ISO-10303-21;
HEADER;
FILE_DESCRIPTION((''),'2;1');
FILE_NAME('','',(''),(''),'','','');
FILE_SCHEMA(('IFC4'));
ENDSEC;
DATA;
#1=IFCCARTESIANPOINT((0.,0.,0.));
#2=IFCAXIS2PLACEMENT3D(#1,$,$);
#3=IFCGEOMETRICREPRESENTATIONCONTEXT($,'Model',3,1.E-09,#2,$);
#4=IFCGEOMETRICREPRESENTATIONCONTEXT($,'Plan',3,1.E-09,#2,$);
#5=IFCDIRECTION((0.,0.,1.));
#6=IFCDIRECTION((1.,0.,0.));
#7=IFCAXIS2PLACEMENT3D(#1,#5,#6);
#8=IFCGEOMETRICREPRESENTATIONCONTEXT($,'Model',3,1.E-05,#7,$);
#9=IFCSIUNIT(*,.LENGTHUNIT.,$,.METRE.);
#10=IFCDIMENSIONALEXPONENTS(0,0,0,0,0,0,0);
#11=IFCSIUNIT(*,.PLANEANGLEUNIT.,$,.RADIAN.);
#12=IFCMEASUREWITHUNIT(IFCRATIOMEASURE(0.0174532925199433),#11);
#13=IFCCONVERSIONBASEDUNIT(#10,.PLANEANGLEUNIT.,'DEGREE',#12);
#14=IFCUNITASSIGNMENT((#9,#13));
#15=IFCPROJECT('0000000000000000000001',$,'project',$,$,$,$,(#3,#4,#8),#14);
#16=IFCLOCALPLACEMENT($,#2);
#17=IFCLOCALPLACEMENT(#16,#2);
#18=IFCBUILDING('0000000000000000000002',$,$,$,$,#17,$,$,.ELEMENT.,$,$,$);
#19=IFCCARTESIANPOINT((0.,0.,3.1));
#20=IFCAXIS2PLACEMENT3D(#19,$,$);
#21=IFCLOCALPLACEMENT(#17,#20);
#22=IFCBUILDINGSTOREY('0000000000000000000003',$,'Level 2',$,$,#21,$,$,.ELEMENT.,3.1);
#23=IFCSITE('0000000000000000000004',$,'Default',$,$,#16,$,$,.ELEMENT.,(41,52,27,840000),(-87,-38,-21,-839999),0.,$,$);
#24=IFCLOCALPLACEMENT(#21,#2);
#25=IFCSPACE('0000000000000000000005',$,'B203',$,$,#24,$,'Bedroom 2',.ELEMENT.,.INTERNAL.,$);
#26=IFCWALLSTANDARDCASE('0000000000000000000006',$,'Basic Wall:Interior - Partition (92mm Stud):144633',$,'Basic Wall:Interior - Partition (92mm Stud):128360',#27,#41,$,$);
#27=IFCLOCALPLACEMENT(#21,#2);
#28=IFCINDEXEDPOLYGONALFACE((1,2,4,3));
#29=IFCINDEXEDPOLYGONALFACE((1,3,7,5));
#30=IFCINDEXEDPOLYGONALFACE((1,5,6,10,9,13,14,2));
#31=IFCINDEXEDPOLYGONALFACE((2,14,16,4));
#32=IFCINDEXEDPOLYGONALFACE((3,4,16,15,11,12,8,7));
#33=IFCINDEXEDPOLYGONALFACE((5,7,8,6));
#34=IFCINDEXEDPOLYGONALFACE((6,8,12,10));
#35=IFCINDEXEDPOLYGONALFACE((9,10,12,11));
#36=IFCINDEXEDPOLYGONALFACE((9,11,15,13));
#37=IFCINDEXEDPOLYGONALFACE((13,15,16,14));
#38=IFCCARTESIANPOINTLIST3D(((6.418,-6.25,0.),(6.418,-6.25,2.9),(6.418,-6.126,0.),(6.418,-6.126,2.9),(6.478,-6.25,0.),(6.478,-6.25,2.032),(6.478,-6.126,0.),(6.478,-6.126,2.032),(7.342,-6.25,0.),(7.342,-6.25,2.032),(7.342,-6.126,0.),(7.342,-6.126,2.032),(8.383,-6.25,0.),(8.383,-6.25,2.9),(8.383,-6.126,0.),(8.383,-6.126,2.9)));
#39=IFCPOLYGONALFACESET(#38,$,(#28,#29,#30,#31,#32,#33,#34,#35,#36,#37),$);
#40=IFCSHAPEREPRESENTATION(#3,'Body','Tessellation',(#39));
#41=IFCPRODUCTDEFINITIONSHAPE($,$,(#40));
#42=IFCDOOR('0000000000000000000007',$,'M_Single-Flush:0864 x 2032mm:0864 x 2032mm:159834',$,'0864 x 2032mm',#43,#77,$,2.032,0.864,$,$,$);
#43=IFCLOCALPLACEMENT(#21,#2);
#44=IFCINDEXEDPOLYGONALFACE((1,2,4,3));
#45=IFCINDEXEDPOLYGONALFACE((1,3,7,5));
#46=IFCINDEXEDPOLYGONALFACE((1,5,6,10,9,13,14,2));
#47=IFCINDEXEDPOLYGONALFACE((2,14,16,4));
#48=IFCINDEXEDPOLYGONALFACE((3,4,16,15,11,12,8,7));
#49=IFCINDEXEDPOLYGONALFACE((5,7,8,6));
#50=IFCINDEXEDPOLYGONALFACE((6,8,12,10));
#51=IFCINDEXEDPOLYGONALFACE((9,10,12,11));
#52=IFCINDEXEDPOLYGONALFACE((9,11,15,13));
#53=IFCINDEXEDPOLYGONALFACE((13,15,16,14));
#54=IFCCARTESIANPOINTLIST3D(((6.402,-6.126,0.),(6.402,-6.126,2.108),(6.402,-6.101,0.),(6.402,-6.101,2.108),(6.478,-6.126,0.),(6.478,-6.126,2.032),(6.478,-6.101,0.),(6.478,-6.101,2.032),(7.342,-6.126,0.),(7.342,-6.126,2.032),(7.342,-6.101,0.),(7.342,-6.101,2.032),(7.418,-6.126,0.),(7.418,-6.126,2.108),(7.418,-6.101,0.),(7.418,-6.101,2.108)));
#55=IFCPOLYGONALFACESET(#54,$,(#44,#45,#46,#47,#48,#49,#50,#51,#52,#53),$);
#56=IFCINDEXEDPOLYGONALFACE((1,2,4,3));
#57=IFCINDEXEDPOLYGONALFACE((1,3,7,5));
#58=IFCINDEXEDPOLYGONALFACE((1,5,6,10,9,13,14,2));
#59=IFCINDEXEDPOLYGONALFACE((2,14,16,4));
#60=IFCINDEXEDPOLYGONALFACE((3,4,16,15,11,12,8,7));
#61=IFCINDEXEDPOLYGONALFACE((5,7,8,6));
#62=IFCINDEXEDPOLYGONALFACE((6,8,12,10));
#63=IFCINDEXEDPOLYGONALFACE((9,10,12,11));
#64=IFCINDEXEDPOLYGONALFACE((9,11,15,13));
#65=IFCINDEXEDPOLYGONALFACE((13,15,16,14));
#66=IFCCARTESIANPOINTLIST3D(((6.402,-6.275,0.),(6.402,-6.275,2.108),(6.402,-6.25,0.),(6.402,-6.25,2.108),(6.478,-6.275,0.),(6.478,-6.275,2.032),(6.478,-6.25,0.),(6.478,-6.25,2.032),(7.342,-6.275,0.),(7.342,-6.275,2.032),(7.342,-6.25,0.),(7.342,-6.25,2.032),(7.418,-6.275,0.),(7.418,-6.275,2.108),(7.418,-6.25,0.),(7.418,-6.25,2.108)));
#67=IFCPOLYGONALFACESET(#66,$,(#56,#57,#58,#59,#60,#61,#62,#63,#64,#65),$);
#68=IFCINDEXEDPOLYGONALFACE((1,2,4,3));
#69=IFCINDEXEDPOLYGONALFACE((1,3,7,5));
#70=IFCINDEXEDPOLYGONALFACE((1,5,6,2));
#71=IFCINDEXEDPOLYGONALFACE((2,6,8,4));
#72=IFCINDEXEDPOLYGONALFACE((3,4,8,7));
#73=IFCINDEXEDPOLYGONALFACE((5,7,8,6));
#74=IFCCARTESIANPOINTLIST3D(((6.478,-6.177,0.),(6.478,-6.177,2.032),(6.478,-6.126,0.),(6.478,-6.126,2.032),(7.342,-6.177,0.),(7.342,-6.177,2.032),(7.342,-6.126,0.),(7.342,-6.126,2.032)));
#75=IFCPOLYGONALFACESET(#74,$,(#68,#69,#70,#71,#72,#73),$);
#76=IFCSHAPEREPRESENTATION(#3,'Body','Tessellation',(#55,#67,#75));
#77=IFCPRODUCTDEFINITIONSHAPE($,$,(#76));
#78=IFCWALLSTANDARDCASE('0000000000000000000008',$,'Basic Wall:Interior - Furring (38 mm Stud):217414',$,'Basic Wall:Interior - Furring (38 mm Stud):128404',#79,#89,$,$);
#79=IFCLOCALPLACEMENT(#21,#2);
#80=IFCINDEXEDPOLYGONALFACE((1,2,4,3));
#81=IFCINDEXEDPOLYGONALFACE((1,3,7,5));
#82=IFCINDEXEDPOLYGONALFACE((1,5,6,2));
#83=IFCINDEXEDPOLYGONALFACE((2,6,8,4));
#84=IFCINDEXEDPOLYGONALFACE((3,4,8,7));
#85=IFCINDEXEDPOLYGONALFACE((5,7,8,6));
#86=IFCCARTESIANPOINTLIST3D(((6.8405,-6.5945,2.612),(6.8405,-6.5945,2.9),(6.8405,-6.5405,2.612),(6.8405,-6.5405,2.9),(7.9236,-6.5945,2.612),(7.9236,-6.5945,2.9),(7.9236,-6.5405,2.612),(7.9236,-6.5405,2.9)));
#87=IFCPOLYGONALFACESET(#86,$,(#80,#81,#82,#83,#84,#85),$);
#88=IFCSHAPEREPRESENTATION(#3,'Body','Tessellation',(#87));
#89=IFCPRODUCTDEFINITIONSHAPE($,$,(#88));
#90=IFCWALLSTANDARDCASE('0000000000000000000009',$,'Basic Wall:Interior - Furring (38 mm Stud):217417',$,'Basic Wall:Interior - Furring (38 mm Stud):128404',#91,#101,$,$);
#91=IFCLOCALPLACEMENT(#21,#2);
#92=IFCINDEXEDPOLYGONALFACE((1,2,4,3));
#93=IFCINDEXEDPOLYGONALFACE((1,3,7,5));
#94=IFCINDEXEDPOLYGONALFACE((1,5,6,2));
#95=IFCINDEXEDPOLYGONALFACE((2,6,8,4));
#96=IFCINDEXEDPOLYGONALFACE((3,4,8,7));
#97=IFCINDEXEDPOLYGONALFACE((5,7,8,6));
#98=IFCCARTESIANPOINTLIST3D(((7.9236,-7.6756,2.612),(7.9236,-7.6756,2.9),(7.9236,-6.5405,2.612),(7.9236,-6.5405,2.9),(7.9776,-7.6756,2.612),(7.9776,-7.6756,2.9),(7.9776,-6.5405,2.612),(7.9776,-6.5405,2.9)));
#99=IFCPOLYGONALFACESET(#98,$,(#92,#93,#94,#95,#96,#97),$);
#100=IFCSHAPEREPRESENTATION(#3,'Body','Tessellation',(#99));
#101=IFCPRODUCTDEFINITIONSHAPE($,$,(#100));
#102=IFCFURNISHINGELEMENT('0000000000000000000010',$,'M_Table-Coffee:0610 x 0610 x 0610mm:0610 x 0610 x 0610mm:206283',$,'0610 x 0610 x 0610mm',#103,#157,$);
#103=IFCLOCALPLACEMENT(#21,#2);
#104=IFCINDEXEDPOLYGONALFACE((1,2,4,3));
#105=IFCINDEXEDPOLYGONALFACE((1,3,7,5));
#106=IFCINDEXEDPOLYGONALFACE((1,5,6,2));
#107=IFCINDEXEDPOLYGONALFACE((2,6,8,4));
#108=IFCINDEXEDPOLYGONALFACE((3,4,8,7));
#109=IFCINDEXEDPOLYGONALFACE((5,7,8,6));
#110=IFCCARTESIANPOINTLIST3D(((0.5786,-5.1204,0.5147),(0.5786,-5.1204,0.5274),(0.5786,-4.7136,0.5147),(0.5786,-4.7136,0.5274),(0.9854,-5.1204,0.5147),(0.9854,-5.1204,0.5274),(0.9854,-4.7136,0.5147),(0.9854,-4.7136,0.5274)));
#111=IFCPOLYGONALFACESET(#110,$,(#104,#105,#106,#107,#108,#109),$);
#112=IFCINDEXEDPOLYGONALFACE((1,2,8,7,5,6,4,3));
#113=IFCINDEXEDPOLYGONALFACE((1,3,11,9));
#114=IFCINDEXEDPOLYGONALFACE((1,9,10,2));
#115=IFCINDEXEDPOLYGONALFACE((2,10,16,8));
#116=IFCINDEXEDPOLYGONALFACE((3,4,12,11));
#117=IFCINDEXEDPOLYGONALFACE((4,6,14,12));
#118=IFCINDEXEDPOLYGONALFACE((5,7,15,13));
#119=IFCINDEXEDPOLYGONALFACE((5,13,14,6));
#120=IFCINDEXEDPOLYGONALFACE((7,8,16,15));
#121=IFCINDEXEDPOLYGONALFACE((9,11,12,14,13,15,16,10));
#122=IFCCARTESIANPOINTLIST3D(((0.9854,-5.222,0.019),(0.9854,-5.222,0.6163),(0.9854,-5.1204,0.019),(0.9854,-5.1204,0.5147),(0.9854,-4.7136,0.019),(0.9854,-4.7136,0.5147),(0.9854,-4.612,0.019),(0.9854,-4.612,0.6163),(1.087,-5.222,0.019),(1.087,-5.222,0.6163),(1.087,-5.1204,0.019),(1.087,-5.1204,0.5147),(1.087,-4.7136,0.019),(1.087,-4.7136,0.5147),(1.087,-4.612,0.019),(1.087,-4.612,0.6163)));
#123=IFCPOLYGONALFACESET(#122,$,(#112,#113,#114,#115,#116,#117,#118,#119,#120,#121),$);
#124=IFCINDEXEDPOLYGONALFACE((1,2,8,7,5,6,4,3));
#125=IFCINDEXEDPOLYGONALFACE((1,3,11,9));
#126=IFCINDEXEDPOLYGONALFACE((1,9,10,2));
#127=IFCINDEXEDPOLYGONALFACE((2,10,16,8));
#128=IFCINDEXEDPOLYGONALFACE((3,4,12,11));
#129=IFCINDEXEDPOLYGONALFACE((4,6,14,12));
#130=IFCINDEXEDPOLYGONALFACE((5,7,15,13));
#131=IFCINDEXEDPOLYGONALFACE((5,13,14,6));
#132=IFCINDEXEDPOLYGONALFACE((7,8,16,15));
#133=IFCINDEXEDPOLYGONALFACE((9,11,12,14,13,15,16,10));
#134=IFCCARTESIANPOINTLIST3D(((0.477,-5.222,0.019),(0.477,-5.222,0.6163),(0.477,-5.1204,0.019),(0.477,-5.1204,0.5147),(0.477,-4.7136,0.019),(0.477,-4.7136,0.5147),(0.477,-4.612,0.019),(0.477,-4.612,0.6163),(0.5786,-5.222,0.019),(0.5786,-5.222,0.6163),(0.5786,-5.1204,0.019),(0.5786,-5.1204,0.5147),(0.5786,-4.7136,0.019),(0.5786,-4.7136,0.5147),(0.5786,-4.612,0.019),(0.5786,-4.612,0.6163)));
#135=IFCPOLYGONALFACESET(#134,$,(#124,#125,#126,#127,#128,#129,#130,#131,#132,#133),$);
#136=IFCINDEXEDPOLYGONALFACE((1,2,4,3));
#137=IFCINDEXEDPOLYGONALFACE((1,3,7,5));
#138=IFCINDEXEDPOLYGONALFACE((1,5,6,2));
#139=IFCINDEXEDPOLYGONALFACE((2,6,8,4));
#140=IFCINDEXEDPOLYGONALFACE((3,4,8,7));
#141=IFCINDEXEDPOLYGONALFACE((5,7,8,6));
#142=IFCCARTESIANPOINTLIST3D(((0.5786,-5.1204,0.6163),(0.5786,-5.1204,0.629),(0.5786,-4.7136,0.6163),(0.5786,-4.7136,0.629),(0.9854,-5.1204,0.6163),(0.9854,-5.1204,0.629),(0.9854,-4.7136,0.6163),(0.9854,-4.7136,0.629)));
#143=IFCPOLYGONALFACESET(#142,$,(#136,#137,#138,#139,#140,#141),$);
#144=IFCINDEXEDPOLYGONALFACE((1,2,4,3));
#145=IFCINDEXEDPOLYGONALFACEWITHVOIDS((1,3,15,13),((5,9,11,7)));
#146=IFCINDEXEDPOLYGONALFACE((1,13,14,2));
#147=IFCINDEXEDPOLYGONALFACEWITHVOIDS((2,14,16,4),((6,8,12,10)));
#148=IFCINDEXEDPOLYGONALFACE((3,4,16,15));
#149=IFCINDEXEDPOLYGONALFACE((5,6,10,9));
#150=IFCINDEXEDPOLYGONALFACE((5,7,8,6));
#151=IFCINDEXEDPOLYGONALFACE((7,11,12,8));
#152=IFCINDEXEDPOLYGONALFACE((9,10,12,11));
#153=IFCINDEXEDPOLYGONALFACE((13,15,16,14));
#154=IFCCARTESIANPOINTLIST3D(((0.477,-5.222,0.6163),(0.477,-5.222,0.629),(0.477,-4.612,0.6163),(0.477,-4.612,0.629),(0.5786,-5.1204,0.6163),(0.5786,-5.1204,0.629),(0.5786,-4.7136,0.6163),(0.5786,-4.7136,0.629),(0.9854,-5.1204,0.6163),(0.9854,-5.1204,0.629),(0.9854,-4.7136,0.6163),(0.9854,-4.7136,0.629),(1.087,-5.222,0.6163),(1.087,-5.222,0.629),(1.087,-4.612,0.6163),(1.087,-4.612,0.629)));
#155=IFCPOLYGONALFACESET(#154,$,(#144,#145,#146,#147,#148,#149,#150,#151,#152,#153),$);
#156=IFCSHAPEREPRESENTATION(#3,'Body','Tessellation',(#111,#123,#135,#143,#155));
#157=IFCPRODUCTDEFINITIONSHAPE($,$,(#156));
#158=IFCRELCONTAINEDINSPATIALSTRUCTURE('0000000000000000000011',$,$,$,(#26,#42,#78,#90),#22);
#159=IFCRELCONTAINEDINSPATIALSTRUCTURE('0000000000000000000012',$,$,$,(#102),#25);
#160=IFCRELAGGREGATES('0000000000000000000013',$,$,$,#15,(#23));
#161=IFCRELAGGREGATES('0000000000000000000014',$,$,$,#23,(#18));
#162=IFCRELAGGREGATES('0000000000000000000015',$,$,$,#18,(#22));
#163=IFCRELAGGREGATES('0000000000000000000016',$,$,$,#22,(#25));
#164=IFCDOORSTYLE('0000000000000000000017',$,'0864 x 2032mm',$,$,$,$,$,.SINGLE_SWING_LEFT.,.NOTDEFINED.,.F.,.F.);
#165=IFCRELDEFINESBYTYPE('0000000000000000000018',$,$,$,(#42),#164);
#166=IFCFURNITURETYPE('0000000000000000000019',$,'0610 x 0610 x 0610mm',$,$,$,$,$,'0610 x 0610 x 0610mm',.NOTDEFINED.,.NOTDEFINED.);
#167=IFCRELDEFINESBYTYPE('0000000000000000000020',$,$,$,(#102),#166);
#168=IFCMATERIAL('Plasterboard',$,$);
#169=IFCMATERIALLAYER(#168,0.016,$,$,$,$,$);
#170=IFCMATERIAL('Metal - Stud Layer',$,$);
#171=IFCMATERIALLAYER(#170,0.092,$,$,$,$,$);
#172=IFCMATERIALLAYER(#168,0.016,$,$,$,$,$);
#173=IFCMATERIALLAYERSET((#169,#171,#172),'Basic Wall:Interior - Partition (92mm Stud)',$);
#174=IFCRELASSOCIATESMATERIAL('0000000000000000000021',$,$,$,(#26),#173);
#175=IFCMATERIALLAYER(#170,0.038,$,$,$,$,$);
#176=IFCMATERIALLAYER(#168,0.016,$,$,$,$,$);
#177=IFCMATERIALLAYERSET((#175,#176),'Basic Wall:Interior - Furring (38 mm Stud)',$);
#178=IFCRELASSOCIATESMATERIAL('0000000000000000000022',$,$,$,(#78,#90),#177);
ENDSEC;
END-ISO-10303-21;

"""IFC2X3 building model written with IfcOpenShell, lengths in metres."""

from ifc_helpers import new_model, entity, si_unit, converted_unit, frame, frame_2d, origin, origin_with_axes, origin_2d_with_axis, place, context, project, spatial, polyline, rectangle, outline, extrude, source, transform, mapped, material, layer, layer_set, layer_usage, type_object, type_shapes, element, fill, save


model = new_model("IFC2X3")

# Units and contexts
model_context_1 = context("Model", 3, precision=1e-09, world=origin())
plan_context = context("Plan", 3, precision=1e-09, world=origin())
model_context_2 = context("Model", 3, precision=1e-05, world=origin_with_axes())
ifc_project = project(units=[si_unit("LENGTHUNIT", "METRE"), converted_unit("PLANEANGLEUNIT", "DEGREE", entity("IfcRatioMeasure", 0.0174532925199433), si_unit("PLANEANGLEUNIT", "RADIAN"), dimensions=[0, 0, 0, 0, 0, 0, 0])], contexts=[model_context_1, plan_context, model_context_2])

# Site, building, storey
site_placement = place(None, origin())
site = spatial("IfcSite", under=ifc_project, at=site_placement, Name="Default", CompositionType="ELEMENT", RefLatitude=(41, 52, 27, 840000), RefLongitude=(-87, -38, -21, -839999), RefElevation=0.0)
building_placement = place(site_placement, origin())
building = spatial("IfcBuilding", under=site, at=building_placement, CompositionType="ELEMENT")
storey_placement = place(building_placement, frame((0.0, 0.0, 3.1)))
storey = spatial("IfcBuildingStorey", under=building, at=storey_placement, Name="Level 2", CompositionType="ELEMENT", Elevation=3.1)

# Shared definitions
ifc_material_1 = material(Name="Metal - Stud Layer")
ifc_material_2 = material(Name="Plasterboard")

# Wall, opening, door
ifc_layer_1 = layer(ifc_material_2, 0.016)
ifc_layer_2 = layer(ifc_material_1, 0.092)
ifc_layer_3 = layer(ifc_material_2, 0.016)
ifc_layer_set_1 = layer_set([ifc_layer_1, ifc_layer_2, ifc_layer_3], Name="Basic Wall:Interior - Partition (92mm Stud)")
ifc_layer_usage_1 = layer_usage(ifc_layer_set_1, "AXIS2", "NEGATIVE", 0.062)
wall_1_placement = place(storey_placement, frame((6.418, -6.188, 0.0)))
wall_1 = element("IfcWallStandardCase", 1, at=wall_1_placement, inside=storey, material=ifc_layer_usage_1, Name="Basic Wall:Interior - Partition (92mm Stud):144633", ObjectType="Basic Wall:Interior - Partition (92mm Stud):128360", context=model_context_1, shape_type="SweptSolid", body=[
    extrude(rectangle(XDim=1.965, YDim=0.124, at=frame_2d((0.9825, 0.0), x_axis=(-1.0, 0.0))), origin(), (0.0, 0.0, 1.0), 2.9),
])
opening_1_placement = place(wall_1_placement, frame((0.06, -0.062, 0.0)))
opening_1 = element("IfcOpeningElement", 2, at=opening_1_placement, cuts=wall_1, ObjectType="Opening", context=model_context_1, shape_type="SweptSolid", body=[
    extrude(rectangle(XDim=0.864, YDim=2.032, at=frame_2d((1.016, 0.432), x_axis=(0.0, -1.0))), frame((0.0, 0.0, 0.0), z_axis=(0.0, 1.0, 0.0), x_axis=(0.0, 0.0, 1.0)), (0.0, 0.0, 1.0), 0.124),
])
door_style_1 = type_object("IfcDoorStyle", Name="0864 x 2032mm", ConstructionType="NOTDEFINED", OperationType="SINGLE_SWING_LEFT", ParameterTakesPrecedence=False, Sizeable=False)
shared_shape_1 = source(origin(), model_context_1, "Body", "SweptSolid", [
    extrude(outline(polyline([(-0.508, -1.073), (0.508, -1.073), (0.508, 1.035), (0.432, 1.035), (0.432, -0.997), (-0.432, -0.997), (-0.432, 1.035), (-0.508, 1.035), (-0.508, -1.073)])), frame((0.432, 0.149, 1.035), z_axis=(0.0, -1.0, 0.0), x_axis=(-1.0, 0.0, 0.0)), (0.0, 0.0, 1.0), 0.025),
    extrude(outline(polyline([(-1.073, -0.508), (1.035, -0.508), (1.035, -0.432), (-0.997, -0.432), (-0.997, 0.432), (1.035, 0.432), (1.035, 0.508), (-1.073, 0.508), (-1.073, -0.508)])), frame((0.432, 0.0, 1.035), z_axis=(0.0, -1.0, 0.0), x_axis=(0.0, 0.0, -1.0)), (0.0, 0.0, 1.0), 0.025),
    extrude(rectangle(XDim=0.864, YDim=0.051, at=origin_2d_with_axis()), frame((0.432, 0.0985, 0.0)), (0.0, 0.0, 1.0), 2.032),
])
type_shapes(door_style_1, [shared_shape_1])
door_1_placement = place(opening_1_placement, origin())
door_1 = element("IfcDoor", 3, at=door_1_placement, inside=storey, type_object=door_style_1, Name="M_Single-Flush:0864 x 2032mm:0864 x 2032mm:159834", ObjectType="0864 x 2032mm", OverallHeight=2.032, OverallWidth=0.864, context=model_context_1, shape_type="MappedRepresentation", body=[
    mapped(shared_shape_1, transform((0.0, 0.0, 0.0), scale=1.0)),
])
fill(opening_1, door_1)

# Walls
ifc_layer_4 = layer(ifc_material_1, 0.038)
ifc_layer_5 = layer(ifc_material_2, 0.016)
ifc_layer_set_2 = layer_set([ifc_layer_4, ifc_layer_5], Name="Basic Wall:Interior - Furring (38 mm Stud)")
ifc_layer_usage_2 = layer_usage(ifc_layer_set_2, "AXIS2", "NEGATIVE", 0.027)
wall_2_placement = place(storey_placement, frame((6.8405, -6.5675, 2.612)))
element("IfcWallStandardCase", 4, at=wall_2_placement, inside=storey, material=ifc_layer_usage_2, Name="Basic Wall:Interior - Furring (38 mm Stud):217414", ObjectType="Basic Wall:Interior - Furring (38 mm Stud):128404", context=model_context_1, shape_type="SweptSolid", body=[
    extrude(rectangle(XDim=1.0831, YDim=0.054, at=frame_2d((0.5415, 0.0), x_axis=(-1.0, 0.0))), origin(), (0.0, 0.0, 1.0), 0.288),
])
ifc_layer_usage_3 = layer_usage(ifc_layer_set_2, "AXIS2", "NEGATIVE", 0.027)
wall_3_placement = place(storey_placement, frame((7.9506, -6.5405, 2.612), z_axis=(0.0, 0.0, 1.0), x_axis=(0.0, -1.0, 0.0)))
element("IfcWallStandardCase", 5, at=wall_3_placement, inside=storey, material=ifc_layer_usage_3, Name="Basic Wall:Interior - Furring (38 mm Stud):217417", ObjectType="Basic Wall:Interior - Furring (38 mm Stud):128404", context=model_context_1, shape_type="SweptSolid", body=[
    extrude(rectangle(XDim=1.1351, YDim=0.054, at=frame_2d((0.5675, 0.0), x_axis=(-1.0, 0.0))), origin(), (0.0, 0.0, 1.0), 0.288),
])

# Shared definitions
space_1_placement = place(storey_placement, origin())
space_1 = spatial("IfcSpace", under=storey, at=space_1_placement, Name="B203", LongName="Bedroom 2", CompositionType="ELEMENT", InteriorOrExteriorSpace="INTERNAL")

# Furnishing element
furniture_type = type_object("IfcFurnitureType", Name="0610 x 0610 x 0610mm", ElementType="0610 x 0610 x 0610mm", AssemblyPlace="NOTDEFINED")
shared_shape_2 = source(origin(), model_context_1, "Body", "SweptSolid", [
    extrude(rectangle(XDim=0.4068, YDim=0.4068, at=origin_2d_with_axis()), frame((0.0183, 0.0952, 0.4957), z_axis=(0.0, 0.0, 1.0), x_axis=(-1.0, 0.0, 0.0)), (0.0, 0.0, 1.0), 0.0127),
    extrude(outline(polyline([(-0.2732, -0.305), (0.324, -0.305), (0.324, 0.305), (-0.2732, 0.305), (-0.2732, 0.2034), (0.2225, 0.2034), (0.2225, -0.2034), (-0.2732, -0.2034), (-0.2732, -0.305)])), frame((0.2217, 0.0952, 0.2732), z_axis=(1.0, 0.0, 0.0), x_axis=(0.0, 0.0, 1.0)), (0.0, 0.0, 1.0), 0.1016),
    extrude(outline(polyline([(-0.305, -0.3241), (0.305, -0.3241), (0.305, 0.2733), (0.2034, 0.2733), (0.2034, -0.2224), (-0.2034, -0.2224), (-0.2034, 0.2733), (-0.305, 0.2733), (-0.305, -0.3241)])), frame((-0.2867, 0.0952, 0.2733), z_axis=(1.0, 0.0, 0.0), x_axis=(0.0, -1.0, 0.0)), (0.0, 0.0, 1.0), 0.1016),
    extrude(rectangle(XDim=0.4068, YDim=0.4068, at=origin_2d_with_axis()), frame((0.0183, 0.0952, 0.5973), z_axis=(0.0, 0.0, 1.0), x_axis=(-1.0, 0.0, 0.0)), (0.0, 0.0, 1.0), 0.0127),
    extrude(outline(polyline([(-0.305, -0.305), (0.305, -0.305), (0.305, 0.305), (-0.305, 0.305), (-0.305, -0.305)]), holes=[polyline([(-0.2034, -0.2034), (-0.2034, 0.2034), (0.2034, 0.2034), (0.2034, -0.2034), (-0.2034, -0.2034)])]), frame((0.0183, 0.0952, 0.5973), z_axis=(0.0, 0.0, 1.0), x_axis=(-1.0, 0.0, 0.0)), (0.0, 0.0, 1.0), 0.0127),
])
type_shapes(furniture_type, [shared_shape_2])
furnishing_1_placement = place(space_1_placement, frame((0.7637, -5.0122, 0.019)))
element("IfcFurnishingElement", 6, at=furnishing_1_placement, inside=space_1, type_object=furniture_type, Name="M_Table-Coffee:0610 x 0610 x 0610mm:0610 x 0610 x 0610mm:206283", ObjectType="0610 x 0610 x 0610mm", context=model_context_1, shape_type="MappedRepresentation", body=[
    mapped(shared_shape_2, transform((0.0, 0.0, 0.0), scale=1.0)),
])

save(model, "model.ifc")
